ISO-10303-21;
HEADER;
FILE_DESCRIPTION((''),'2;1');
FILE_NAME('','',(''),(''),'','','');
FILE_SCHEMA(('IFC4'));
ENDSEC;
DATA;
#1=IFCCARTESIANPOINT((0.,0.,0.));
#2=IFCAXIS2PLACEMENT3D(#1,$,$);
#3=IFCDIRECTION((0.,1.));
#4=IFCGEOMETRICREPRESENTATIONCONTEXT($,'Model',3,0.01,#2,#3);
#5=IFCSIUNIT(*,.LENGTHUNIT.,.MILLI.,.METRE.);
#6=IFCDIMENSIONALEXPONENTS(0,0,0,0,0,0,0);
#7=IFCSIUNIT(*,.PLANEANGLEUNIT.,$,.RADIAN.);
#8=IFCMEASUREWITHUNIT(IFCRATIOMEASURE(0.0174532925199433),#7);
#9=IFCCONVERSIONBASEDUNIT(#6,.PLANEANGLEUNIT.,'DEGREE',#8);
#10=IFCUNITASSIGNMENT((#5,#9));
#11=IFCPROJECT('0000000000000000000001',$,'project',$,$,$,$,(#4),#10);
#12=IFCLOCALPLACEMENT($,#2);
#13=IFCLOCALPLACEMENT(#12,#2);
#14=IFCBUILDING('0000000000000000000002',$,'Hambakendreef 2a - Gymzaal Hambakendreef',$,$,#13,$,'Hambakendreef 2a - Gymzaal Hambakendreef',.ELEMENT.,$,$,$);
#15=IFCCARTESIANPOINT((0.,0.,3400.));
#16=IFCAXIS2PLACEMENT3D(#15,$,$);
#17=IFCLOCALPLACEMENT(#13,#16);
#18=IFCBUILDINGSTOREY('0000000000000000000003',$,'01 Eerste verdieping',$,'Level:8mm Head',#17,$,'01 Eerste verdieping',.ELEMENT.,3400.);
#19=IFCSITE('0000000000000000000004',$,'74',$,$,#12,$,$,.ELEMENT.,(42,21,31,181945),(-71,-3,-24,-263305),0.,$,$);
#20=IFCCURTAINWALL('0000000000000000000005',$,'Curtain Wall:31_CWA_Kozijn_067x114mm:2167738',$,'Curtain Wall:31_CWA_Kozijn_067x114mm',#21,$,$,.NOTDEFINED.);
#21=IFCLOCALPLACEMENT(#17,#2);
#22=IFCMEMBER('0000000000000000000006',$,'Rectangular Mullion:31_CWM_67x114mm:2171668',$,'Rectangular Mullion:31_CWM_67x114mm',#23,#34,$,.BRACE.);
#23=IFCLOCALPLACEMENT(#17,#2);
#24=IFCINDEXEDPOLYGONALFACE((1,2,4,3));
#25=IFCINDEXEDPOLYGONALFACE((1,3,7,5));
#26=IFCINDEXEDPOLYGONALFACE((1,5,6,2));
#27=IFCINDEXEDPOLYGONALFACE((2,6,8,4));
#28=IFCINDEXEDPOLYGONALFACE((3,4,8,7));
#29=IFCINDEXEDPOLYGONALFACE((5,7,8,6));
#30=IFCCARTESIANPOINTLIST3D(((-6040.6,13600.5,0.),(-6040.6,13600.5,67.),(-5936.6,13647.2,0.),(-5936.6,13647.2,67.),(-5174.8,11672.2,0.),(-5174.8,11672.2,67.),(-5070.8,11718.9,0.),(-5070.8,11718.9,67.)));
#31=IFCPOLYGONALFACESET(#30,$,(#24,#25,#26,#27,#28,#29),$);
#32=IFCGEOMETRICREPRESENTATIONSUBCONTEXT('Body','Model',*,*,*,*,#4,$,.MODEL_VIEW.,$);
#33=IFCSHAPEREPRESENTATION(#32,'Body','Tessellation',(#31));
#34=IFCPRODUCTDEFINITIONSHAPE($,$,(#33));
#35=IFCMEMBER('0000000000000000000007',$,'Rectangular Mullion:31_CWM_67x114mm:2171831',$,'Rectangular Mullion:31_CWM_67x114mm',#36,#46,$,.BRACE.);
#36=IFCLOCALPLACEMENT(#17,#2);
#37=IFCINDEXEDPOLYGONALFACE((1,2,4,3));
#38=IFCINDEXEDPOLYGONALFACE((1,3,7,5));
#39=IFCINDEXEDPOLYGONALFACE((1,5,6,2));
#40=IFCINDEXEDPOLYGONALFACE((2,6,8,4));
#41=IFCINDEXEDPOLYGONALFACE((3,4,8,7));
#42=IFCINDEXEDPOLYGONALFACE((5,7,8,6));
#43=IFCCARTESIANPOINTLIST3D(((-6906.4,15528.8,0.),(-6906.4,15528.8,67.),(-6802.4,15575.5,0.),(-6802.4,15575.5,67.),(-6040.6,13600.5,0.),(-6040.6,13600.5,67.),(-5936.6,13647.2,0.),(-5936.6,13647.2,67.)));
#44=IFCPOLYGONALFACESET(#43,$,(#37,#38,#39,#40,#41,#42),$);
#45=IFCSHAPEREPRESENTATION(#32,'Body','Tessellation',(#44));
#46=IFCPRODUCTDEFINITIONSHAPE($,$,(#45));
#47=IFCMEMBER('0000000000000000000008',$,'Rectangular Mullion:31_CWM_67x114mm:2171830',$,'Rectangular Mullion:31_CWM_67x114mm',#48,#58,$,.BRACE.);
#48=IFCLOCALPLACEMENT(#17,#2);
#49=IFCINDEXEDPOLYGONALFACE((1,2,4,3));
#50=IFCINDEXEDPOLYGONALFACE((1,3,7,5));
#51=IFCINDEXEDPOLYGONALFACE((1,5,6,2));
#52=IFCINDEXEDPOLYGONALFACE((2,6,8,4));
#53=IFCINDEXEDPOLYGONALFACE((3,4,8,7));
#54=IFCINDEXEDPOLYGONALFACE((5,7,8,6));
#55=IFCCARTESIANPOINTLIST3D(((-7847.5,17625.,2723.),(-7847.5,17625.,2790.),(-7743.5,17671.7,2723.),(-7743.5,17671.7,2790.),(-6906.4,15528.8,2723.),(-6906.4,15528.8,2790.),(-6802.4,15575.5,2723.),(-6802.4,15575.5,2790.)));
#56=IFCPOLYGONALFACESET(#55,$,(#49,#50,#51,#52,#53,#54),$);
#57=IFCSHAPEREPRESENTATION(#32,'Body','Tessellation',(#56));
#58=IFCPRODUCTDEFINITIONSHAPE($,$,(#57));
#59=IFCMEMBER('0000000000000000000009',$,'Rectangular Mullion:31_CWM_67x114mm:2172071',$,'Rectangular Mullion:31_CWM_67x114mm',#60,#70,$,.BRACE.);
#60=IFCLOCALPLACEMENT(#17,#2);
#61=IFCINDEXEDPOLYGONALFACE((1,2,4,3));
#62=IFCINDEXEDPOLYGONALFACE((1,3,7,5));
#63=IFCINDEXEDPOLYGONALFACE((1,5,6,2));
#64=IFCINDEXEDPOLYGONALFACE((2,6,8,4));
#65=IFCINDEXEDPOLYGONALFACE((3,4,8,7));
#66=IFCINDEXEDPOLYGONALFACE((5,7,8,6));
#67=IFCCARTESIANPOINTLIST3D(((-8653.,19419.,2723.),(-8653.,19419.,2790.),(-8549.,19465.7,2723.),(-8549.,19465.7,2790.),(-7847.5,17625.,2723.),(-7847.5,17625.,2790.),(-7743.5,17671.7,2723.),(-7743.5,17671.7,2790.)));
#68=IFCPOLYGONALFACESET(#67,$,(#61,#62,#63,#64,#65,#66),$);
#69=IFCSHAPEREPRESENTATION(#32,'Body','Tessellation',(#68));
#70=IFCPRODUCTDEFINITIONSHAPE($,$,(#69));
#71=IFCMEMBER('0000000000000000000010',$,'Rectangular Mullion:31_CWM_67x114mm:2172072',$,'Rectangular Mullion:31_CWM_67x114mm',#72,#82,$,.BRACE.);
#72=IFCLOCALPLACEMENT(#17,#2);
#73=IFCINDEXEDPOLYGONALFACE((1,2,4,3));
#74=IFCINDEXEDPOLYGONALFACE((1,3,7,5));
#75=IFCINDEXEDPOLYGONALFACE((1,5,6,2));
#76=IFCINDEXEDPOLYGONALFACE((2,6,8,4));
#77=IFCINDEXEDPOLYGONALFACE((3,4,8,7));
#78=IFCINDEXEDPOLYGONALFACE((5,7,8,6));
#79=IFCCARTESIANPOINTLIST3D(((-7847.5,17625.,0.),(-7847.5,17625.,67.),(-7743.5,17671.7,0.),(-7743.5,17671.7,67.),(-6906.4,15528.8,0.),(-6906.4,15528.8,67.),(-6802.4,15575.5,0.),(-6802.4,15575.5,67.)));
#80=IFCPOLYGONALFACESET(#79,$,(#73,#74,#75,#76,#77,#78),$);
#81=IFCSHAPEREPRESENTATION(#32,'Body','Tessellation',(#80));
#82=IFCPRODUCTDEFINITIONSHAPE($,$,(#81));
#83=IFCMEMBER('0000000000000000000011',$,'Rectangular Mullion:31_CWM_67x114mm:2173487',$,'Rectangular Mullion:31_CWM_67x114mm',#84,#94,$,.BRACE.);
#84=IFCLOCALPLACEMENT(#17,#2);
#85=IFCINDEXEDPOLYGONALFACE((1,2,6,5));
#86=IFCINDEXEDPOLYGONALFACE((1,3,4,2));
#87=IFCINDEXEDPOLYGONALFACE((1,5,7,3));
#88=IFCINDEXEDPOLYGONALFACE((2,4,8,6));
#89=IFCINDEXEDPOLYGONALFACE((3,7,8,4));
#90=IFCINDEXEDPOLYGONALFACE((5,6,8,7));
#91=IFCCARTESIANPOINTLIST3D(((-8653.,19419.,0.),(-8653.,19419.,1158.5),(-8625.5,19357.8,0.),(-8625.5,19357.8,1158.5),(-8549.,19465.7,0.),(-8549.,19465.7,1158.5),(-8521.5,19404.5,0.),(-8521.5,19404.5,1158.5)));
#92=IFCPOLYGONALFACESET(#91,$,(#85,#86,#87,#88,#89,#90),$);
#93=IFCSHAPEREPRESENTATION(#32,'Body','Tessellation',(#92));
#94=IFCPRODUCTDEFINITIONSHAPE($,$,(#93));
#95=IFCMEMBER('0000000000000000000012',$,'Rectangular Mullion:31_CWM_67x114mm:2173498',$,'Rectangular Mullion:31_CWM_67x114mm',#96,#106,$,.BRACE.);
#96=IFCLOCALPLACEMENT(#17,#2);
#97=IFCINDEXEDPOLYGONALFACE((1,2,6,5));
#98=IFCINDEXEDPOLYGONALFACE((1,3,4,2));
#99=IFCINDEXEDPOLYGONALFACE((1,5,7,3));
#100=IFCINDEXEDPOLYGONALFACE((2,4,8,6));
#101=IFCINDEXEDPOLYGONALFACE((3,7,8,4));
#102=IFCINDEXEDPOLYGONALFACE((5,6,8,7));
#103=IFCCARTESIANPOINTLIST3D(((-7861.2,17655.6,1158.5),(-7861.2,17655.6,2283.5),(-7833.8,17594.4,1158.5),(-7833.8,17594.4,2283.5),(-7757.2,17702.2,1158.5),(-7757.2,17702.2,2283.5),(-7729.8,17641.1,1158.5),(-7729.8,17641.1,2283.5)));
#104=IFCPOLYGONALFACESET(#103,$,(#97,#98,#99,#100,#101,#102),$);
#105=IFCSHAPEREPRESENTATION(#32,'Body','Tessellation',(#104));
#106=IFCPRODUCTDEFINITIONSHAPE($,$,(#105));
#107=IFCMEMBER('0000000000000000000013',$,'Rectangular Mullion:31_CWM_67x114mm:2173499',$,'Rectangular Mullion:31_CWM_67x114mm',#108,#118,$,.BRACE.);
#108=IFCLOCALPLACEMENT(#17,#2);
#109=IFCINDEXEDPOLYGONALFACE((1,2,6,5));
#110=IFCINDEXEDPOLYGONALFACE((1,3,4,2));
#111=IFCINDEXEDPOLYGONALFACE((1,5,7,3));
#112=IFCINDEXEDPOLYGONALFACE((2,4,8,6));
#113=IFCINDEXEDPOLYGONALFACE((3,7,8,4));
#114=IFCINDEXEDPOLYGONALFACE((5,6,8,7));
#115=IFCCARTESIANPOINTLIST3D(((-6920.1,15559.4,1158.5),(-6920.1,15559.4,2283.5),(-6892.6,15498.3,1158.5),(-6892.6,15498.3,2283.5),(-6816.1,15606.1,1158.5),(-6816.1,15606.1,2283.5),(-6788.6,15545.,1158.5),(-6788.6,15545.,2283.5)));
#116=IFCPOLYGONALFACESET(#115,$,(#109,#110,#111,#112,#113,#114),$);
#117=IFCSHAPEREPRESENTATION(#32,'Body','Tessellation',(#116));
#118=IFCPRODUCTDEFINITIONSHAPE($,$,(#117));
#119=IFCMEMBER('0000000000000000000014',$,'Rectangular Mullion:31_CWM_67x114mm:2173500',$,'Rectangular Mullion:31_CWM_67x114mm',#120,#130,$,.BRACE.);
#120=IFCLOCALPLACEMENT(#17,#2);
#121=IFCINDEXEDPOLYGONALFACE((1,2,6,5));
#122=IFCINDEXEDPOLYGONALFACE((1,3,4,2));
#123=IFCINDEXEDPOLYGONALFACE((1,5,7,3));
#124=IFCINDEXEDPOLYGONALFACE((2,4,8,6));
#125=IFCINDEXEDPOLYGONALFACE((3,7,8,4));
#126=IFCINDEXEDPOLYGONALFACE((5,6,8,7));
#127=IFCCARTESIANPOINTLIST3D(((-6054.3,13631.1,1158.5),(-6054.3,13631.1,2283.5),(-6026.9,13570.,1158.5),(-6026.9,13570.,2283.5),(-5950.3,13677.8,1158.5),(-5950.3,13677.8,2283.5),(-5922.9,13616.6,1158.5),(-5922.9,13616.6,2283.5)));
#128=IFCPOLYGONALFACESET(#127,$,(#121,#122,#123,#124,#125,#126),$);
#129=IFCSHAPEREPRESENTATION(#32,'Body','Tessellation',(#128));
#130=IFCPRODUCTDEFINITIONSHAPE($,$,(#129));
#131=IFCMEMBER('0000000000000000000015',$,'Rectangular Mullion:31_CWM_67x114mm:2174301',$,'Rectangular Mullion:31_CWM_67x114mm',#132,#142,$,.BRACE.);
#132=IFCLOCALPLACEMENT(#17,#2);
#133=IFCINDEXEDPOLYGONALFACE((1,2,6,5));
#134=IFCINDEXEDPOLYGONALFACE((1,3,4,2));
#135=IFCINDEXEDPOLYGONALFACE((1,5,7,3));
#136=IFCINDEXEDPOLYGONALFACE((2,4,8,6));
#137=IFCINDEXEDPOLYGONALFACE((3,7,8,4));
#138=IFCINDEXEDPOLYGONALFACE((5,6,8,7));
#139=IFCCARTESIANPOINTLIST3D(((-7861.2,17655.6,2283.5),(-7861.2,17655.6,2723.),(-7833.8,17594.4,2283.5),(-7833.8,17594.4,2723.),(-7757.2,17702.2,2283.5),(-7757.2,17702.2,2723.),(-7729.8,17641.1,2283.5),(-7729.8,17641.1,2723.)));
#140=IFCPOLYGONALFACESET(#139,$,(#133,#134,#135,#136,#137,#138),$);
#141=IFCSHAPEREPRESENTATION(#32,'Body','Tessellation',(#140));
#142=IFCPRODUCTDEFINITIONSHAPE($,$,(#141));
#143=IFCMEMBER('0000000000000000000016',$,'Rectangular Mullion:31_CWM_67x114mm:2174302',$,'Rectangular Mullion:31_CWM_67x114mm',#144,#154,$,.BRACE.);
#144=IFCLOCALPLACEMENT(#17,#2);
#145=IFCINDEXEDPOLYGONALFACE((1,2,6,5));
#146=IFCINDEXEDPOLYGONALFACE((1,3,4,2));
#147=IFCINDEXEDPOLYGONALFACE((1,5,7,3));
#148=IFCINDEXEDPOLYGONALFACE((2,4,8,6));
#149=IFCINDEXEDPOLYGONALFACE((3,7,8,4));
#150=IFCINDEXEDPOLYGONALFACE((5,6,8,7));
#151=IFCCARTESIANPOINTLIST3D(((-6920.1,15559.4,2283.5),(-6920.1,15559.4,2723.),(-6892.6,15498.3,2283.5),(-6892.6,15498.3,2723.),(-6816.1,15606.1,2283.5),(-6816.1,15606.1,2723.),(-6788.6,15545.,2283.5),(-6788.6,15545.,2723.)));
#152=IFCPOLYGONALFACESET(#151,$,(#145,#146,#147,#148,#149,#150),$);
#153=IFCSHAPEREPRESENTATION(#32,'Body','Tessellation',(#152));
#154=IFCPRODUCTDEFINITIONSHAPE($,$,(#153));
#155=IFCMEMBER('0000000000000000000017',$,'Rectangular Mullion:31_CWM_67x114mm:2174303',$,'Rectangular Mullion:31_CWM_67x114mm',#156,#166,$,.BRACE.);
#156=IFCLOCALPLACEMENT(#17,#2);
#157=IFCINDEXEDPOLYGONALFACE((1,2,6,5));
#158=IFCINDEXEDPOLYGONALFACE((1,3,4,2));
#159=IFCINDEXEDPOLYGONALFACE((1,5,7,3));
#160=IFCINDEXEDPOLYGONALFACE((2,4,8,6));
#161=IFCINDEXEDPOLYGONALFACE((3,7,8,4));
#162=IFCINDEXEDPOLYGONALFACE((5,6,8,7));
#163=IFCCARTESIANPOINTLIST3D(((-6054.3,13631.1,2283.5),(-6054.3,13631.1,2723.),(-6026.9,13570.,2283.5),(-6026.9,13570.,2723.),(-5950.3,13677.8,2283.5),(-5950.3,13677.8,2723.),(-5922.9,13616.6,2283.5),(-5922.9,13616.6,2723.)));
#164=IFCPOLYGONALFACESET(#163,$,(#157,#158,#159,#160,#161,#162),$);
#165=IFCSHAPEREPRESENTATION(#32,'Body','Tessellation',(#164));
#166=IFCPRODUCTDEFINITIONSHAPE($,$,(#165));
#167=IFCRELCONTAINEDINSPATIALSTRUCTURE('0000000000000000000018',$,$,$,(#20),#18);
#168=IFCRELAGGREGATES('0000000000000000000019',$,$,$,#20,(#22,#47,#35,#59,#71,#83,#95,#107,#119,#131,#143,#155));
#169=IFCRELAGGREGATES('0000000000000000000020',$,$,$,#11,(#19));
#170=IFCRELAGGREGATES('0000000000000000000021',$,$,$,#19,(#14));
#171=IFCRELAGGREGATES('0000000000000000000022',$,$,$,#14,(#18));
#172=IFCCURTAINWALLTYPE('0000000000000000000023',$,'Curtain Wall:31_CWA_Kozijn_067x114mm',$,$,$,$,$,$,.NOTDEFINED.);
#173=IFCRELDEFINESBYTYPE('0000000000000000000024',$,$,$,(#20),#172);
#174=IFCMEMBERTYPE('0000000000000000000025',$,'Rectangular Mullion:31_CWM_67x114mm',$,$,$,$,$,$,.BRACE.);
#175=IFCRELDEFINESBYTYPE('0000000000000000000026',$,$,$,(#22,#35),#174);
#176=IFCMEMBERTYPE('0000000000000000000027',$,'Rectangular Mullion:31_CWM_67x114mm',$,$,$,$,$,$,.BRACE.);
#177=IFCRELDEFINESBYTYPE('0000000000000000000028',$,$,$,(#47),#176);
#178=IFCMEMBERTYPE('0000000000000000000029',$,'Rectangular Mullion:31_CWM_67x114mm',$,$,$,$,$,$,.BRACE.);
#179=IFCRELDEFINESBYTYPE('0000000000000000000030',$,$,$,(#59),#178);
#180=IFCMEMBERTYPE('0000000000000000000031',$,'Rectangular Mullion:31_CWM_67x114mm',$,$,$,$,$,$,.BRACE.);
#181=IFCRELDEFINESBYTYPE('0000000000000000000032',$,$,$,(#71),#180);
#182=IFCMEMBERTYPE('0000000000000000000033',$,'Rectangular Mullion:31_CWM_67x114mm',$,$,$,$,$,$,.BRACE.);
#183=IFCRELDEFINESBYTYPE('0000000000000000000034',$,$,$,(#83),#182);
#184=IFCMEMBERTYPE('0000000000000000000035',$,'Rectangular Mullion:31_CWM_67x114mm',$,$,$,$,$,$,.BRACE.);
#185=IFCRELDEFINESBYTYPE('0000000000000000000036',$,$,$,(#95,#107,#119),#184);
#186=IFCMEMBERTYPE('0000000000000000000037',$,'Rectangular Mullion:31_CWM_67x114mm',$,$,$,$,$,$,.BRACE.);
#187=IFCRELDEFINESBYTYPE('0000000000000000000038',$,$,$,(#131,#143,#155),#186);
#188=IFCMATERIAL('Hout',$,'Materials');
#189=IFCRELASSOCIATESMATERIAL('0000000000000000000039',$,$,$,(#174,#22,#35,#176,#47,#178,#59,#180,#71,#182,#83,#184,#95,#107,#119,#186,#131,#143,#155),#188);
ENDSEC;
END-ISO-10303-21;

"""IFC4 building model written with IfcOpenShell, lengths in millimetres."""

from ifc_helpers import new_model, entity, si_unit, converted_unit, direction, frame, origin, place, context, subcontext, project, spatial, indexed_curve, outline, extrude, source, transform, mapped, material, type_object, type_shapes, element, aggregate, save


model = new_model("IFC4")

# Units and contexts
model_context = context("Model", 3, precision=0.01, world=origin(), true_north=direction((0.0, 1.0)))
body_context = subcontext(model_context, "Body", "Model", "MODEL_VIEW")
ifc_project = project(units=[si_unit("LENGTHUNIT", "METRE", prefix="MILLI"), converted_unit("PLANEANGLEUNIT", "DEGREE", entity("IfcRatioMeasure", 0.0174532925199433), si_unit("PLANEANGLEUNIT", "RADIAN"), dimensions=[0, 0, 0, 0, 0, 0, 0])], contexts=[model_context])

# Site, building, storey
site_placement = place(None, origin())
site = spatial("IfcSite", under=ifc_project, at=site_placement, Name="74", CompositionType="ELEMENT", RefLatitude=(42, 21, 31, 181945), RefLongitude=(-71, -3, -24, -263305), RefElevation=0.0)
building_placement = place(site_placement, origin())
building = spatial("IfcBuilding", under=site, at=building_placement, Name="Hambakendreef 2a - Gymzaal Hambakendreef", LongName="Hambakendreef 2a - Gymzaal Hambakendreef", CompositionType="ELEMENT")
storey_placement = place(building_placement, frame((0.0, 0.0, 3400.0)))
storey = spatial("IfcBuildingStorey", under=building, at=storey_placement, Name="01 Eerste verdieping", ObjectType="Level:8mm Head", LongName="01 Eerste verdieping", CompositionType="ELEMENT", Elevation=3400.0)

# Curtain wall, members
curtain_wall_type = type_object("IfcCurtainWallType", Name="Curtain Wall:31_CWA_Kozijn_067x114mm", PredefinedType="NOTDEFINED")
curtain_wall_placement = place(storey_placement, frame((0.0, 0.0, -3400.0)))
curtain_wall = element("IfcCurtainWall", 1, at=curtain_wall_placement, inside=storey, type_object=curtain_wall_type, Name="Curtain Wall:31_CWA_Kozijn_067x114mm:2167738", ObjectType="Curtain Wall:31_CWA_Kozijn_067x114mm", PredefinedType="NOTDEFINED")
ifc_material_1 = material(Name="Hout", Category="Materials")
member_type_1 = type_object("IfcMemberType", Name="Rectangular Mullion:31_CWM_67x114mm", PredefinedType="BRACE", material=ifc_material_1)
shared_shape_1 = source(origin(), body_context, "Body", "SweptSolid", [
    extrude(outline(indexed_curve([(-57.0, -33.5), (57.0, -33.5), (57.0, 33.5), (-57.0, 33.5), (-57.0, -33.5)], self_intersect=False)), frame((-33.5, 0.0, -2113.8), z_axis=(0.0, 0.0, 1.0), x_axis=(0.0, -1.0, 0.0)), (0.0, 0.0, 1.0), 2113.8),
])
type_shapes(member_type_1, [shared_shape_1])
member_1_placement = place(storey_placement, frame((-5988.6, 13623.9, 0.0), z_axis=(-0.40959, 0.91227, 0.0), x_axis=(0.0, 0.0, -1.0)))
member_1 = element("IfcMember", 2, at=member_1_placement, type_object=member_type_1, material=ifc_material_1, Name="Rectangular Mullion:31_CWM_67x114mm:2171668", ObjectType="Rectangular Mullion:31_CWM_67x114mm", PredefinedType="BRACE", context=body_context, shape_type="MappedRepresentation", body=[
    mapped(shared_shape_1, transform((0.0, 0.0, 0.0), scale=1.0)),
])
member_2_placement = place(storey_placement, frame((-6854.4, 15552.2, 0.0), z_axis=(-0.40959, 0.91227, 0.0), x_axis=(0.0, 0.0, -1.0)))
member_2 = element("IfcMember", 3, at=member_2_placement, type_object=member_type_1, material=ifc_material_1, Name="Rectangular Mullion:31_CWM_67x114mm:2171831", ObjectType="Rectangular Mullion:31_CWM_67x114mm", PredefinedType="BRACE", context=body_context, shape_type="MappedRepresentation", body=[
    mapped(shared_shape_1, transform((0.0, 0.0, 0.0), scale=1.0)),
])
member_type_2 = type_object("IfcMemberType", Name="Rectangular Mullion:31_CWM_67x114mm", PredefinedType="BRACE", material=ifc_material_1)
shared_shape_2 = source(origin(), body_context, "Body", "SweptSolid", [
    extrude(outline(indexed_curve([(-57.0, -33.5), (57.0, -33.5), (57.0, 33.5), (-57.0, 33.5), (-57.0, -33.5)], self_intersect=False)), frame((-33.5, 0.0, -2297.8), z_axis=(0.0, 0.0, 1.0), x_axis=(0.0, -1.0, 0.0)), (0.0, 0.0, 1.0), 2297.8),
])
type_shapes(member_type_2, [shared_shape_2])
member_3_placement = place(storey_placement, frame((-6854.4, 15552.2, 2790.0), z_axis=(0.40959, -0.91227, 0.0), x_axis=(0.0, 0.0, 1.0)))
member_3 = element("IfcMember", 4, at=member_3_placement, type_object=member_type_2, material=ifc_material_1, Name="Rectangular Mullion:31_CWM_67x114mm:2171830", ObjectType="Rectangular Mullion:31_CWM_67x114mm", PredefinedType="BRACE", context=body_context, shape_type="MappedRepresentation", body=[
    mapped(shared_shape_2, transform((0.0, 0.0, 0.0), scale=1.0)),
])
member_type_3 = type_object("IfcMemberType", Name="Rectangular Mullion:31_CWM_67x114mm", PredefinedType="BRACE", material=ifc_material_1)
shared_shape_3 = source(origin(), body_context, "Body", "SweptSolid", [
    extrude(outline(indexed_curve([(-57.0, -33.5), (57.0, -33.5), (57.0, 33.5), (-57.0, 33.5), (-57.0, -33.5)], self_intersect=False)), frame((-33.5, 0.0, -1966.5), z_axis=(0.0, 0.0, 1.0), x_axis=(0.0, -1.0, 0.0)), (0.0, 0.0, 1.0), 1966.5),
])
type_shapes(member_type_3, [shared_shape_3])
member_4_placement = place(storey_placement, frame((-7795.5, 17648.3, 2790.0), z_axis=(0.40959, -0.91227, 0.0), x_axis=(0.0, 0.0, 1.0)))
member_4 = element("IfcMember", 5, at=member_4_placement, type_object=member_type_3, material=ifc_material_1, Name="Rectangular Mullion:31_CWM_67x114mm:2172071", ObjectType="Rectangular Mullion:31_CWM_67x114mm", PredefinedType="BRACE", context=body_context, shape_type="MappedRepresentation", body=[
    mapped(shared_shape_3, transform((0.0, 0.0, 0.0), scale=1.0)),
])
member_type_4 = type_object("IfcMemberType", Name="Rectangular Mullion:31_CWM_67x114mm", PredefinedType="BRACE", material=ifc_material_1)
shared_shape_4 = source(origin(), body_context, "Body", "SweptSolid", [
    extrude(outline(indexed_curve([(-57.0, -33.5), (57.0, -33.5), (57.0, 33.5), (-57.0, 33.5), (-57.0, -33.5)], self_intersect=False)), frame((-33.5, 0.0, -2297.8), z_axis=(0.0, 0.0, 1.0), x_axis=(0.0, -1.0, 0.0)), (0.0, 0.0, 1.0), 2297.8),
])
type_shapes(member_type_4, [shared_shape_4])
member_5_placement = place(storey_placement, frame((-7795.5, 17648.3, 0.0), z_axis=(-0.40959, 0.91227, 0.0), x_axis=(0.0, 0.0, -1.0)))
member_5 = element("IfcMember", 6, at=member_5_placement, type_object=member_type_4, material=ifc_material_1, Name="Rectangular Mullion:31_CWM_67x114mm:2172072", ObjectType="Rectangular Mullion:31_CWM_67x114mm", PredefinedType="BRACE", context=body_context, shape_type="MappedRepresentation", body=[
    mapped(shared_shape_4, transform((0.0, 0.0, 0.0), scale=1.0)),
])
member_type_5 = type_object("IfcMemberType", Name="Rectangular Mullion:31_CWM_67x114mm", PredefinedType="BRACE", material=ifc_material_1)
shared_shape_5 = source(origin(), body_context, "Body", "SweptSolid", [
    extrude(outline(indexed_curve([(-57.0, -33.5), (57.0, -33.5), (57.0, 33.5), (-57.0, 33.5), (-57.0, -33.5)], self_intersect=False)), frame((-33.5, 0.0, -1158.5), z_axis=(0.0, 0.0, 1.0), x_axis=(0.0, -1.0, 0.0)), (0.0, 0.0, 1.0), 1158.5),
])
type_shapes(member_type_5, [shared_shape_5])
member_6_placement = place(storey_placement, frame((-8601.0, 19442.3, 1158.5), z_axis=(0.0, 0.0, 1.0), x_axis=(-0.40959, 0.91227, 0.0)))
member_6 = element("IfcMember", 7, at=member_6_placement, type_object=member_type_5, material=ifc_material_1, Name="Rectangular Mullion:31_CWM_67x114mm:2173487", ObjectType="Rectangular Mullion:31_CWM_67x114mm", PredefinedType="BRACE", context=body_context, shape_type="MappedRepresentation", body=[
    mapped(shared_shape_5, transform((0.0, 0.0, 0.0), scale=1.0)),
])
member_type_6 = type_object("IfcMemberType", Name="Rectangular Mullion:31_CWM_67x114mm", PredefinedType="BRACE", material=ifc_material_1)
shared_shape_6 = source(origin(), body_context, "Body", "SweptSolid", [
    extrude(outline(indexed_curve([(-57.0, -33.5), (57.0, -33.5), (57.0, 33.5), (-57.0, 33.5), (-57.0, -33.5)], self_intersect=False)), frame((0.0, 0.0, -1125.0), z_axis=(0.0, 0.0, 1.0), x_axis=(0.0, -1.0, 0.0)), (0.0, 0.0, 1.0), 1125.0),
])
type_shapes(member_type_6, [shared_shape_6])
member_7_placement = place(storey_placement, frame((-7795.5, 17648.3, 1158.5), z_axis=(0.0, 0.0, -1.0), x_axis=(0.40959, -0.91227, 0.0)))
member_7 = element("IfcMember", 8, at=member_7_placement, type_object=member_type_6, material=ifc_material_1, Name="Rectangular Mullion:31_CWM_67x114mm:2173498", ObjectType="Rectangular Mullion:31_CWM_67x114mm", PredefinedType="BRACE", context=body_context, shape_type="MappedRepresentation", body=[
    mapped(shared_shape_6, transform((0.0, 0.0, 0.0), scale=1.0)),
])
member_8_placement = place(storey_placement, frame((-6854.4, 15552.2, 1158.5), z_axis=(0.0, 0.0, -1.0), x_axis=(0.40959, -0.91227, 0.0)))
member_8 = element("IfcMember", 9, at=member_8_placement, type_object=member_type_6, material=ifc_material_1, Name="Rectangular Mullion:31_CWM_67x114mm:2173499", ObjectType="Rectangular Mullion:31_CWM_67x114mm", PredefinedType="BRACE", context=body_context, shape_type="MappedRepresentation", body=[
    mapped(shared_shape_6, transform((0.0, 0.0, 0.0), scale=1.0)),
])
member_9_placement = place(storey_placement, frame((-5988.6, 13623.9, 1158.5), z_axis=(0.0, 0.0, -1.0), x_axis=(0.40959, -0.91227, 0.0)))
member_9 = element("IfcMember", 10, at=member_9_placement, type_object=member_type_6, material=ifc_material_1, Name="Rectangular Mullion:31_CWM_67x114mm:2173500", ObjectType="Rectangular Mullion:31_CWM_67x114mm", PredefinedType="BRACE", context=body_context, shape_type="MappedRepresentation", body=[
    mapped(shared_shape_6, transform((0.0, 0.0, 0.0), scale=1.0)),
])
member_type_7 = type_object("IfcMemberType", Name="Rectangular Mullion:31_CWM_67x114mm", PredefinedType="BRACE", material=ifc_material_1)
shared_shape_7 = source(origin(), body_context, "Body", "SweptSolid", [
    extrude(outline(indexed_curve([(-57.0, -33.5), (57.0, -33.5), (57.0, 33.5), (-57.0, 33.5), (-57.0, -33.5)], self_intersect=False)), frame((0.0, 0.0, -439.5), z_axis=(0.0, 0.0, 1.0), x_axis=(0.0, -1.0, 0.0)), (0.0, 0.0, 1.0), 439.5),
])
type_shapes(member_type_7, [shared_shape_7])
member_10_placement = place(storey_placement, frame((-7795.5, 17648.3, 2283.5), z_axis=(0.0, 0.0, -1.0), x_axis=(0.40959, -0.91227, 0.0)))
member_10 = element("IfcMember", 11, at=member_10_placement, type_object=member_type_7, material=ifc_material_1, Name="Rectangular Mullion:31_CWM_67x114mm:2174301", ObjectType="Rectangular Mullion:31_CWM_67x114mm", PredefinedType="BRACE", context=body_context, shape_type="MappedRepresentation", body=[
    mapped(shared_shape_7, transform((0.0, 0.0, 0.0), scale=1.0)),
])
member_11_placement = place(storey_placement, frame((-6854.4, 15552.2, 2283.5), z_axis=(0.0, 0.0, -1.0), x_axis=(0.40959, -0.91227, 0.0)))
member_11 = element("IfcMember", 12, at=member_11_placement, type_object=member_type_7, material=ifc_material_1, Name="Rectangular Mullion:31_CWM_67x114mm:2174302", ObjectType="Rectangular Mullion:31_CWM_67x114mm", PredefinedType="BRACE", context=body_context, shape_type="MappedRepresentation", body=[
    mapped(shared_shape_7, transform((0.0, 0.0, 0.0), scale=1.0)),
])
member_12_placement = place(storey_placement, frame((-5988.6, 13623.9, 2283.5), z_axis=(0.0, 0.0, -1.0), x_axis=(0.40959, -0.91227, 0.0)))
member_12 = element("IfcMember", 13, at=member_12_placement, type_object=member_type_7, material=ifc_material_1, Name="Rectangular Mullion:31_CWM_67x114mm:2174303", ObjectType="Rectangular Mullion:31_CWM_67x114mm", PredefinedType="BRACE", context=body_context, shape_type="MappedRepresentation", body=[
    mapped(shared_shape_7, transform((0.0, 0.0, 0.0), scale=1.0)),
])
aggregate(curtain_wall, [member_1, member_3, member_2, member_4, member_5, member_6, member_7, member_8, member_9, member_10, member_11, member_12])

save(model, "model.ifc")
